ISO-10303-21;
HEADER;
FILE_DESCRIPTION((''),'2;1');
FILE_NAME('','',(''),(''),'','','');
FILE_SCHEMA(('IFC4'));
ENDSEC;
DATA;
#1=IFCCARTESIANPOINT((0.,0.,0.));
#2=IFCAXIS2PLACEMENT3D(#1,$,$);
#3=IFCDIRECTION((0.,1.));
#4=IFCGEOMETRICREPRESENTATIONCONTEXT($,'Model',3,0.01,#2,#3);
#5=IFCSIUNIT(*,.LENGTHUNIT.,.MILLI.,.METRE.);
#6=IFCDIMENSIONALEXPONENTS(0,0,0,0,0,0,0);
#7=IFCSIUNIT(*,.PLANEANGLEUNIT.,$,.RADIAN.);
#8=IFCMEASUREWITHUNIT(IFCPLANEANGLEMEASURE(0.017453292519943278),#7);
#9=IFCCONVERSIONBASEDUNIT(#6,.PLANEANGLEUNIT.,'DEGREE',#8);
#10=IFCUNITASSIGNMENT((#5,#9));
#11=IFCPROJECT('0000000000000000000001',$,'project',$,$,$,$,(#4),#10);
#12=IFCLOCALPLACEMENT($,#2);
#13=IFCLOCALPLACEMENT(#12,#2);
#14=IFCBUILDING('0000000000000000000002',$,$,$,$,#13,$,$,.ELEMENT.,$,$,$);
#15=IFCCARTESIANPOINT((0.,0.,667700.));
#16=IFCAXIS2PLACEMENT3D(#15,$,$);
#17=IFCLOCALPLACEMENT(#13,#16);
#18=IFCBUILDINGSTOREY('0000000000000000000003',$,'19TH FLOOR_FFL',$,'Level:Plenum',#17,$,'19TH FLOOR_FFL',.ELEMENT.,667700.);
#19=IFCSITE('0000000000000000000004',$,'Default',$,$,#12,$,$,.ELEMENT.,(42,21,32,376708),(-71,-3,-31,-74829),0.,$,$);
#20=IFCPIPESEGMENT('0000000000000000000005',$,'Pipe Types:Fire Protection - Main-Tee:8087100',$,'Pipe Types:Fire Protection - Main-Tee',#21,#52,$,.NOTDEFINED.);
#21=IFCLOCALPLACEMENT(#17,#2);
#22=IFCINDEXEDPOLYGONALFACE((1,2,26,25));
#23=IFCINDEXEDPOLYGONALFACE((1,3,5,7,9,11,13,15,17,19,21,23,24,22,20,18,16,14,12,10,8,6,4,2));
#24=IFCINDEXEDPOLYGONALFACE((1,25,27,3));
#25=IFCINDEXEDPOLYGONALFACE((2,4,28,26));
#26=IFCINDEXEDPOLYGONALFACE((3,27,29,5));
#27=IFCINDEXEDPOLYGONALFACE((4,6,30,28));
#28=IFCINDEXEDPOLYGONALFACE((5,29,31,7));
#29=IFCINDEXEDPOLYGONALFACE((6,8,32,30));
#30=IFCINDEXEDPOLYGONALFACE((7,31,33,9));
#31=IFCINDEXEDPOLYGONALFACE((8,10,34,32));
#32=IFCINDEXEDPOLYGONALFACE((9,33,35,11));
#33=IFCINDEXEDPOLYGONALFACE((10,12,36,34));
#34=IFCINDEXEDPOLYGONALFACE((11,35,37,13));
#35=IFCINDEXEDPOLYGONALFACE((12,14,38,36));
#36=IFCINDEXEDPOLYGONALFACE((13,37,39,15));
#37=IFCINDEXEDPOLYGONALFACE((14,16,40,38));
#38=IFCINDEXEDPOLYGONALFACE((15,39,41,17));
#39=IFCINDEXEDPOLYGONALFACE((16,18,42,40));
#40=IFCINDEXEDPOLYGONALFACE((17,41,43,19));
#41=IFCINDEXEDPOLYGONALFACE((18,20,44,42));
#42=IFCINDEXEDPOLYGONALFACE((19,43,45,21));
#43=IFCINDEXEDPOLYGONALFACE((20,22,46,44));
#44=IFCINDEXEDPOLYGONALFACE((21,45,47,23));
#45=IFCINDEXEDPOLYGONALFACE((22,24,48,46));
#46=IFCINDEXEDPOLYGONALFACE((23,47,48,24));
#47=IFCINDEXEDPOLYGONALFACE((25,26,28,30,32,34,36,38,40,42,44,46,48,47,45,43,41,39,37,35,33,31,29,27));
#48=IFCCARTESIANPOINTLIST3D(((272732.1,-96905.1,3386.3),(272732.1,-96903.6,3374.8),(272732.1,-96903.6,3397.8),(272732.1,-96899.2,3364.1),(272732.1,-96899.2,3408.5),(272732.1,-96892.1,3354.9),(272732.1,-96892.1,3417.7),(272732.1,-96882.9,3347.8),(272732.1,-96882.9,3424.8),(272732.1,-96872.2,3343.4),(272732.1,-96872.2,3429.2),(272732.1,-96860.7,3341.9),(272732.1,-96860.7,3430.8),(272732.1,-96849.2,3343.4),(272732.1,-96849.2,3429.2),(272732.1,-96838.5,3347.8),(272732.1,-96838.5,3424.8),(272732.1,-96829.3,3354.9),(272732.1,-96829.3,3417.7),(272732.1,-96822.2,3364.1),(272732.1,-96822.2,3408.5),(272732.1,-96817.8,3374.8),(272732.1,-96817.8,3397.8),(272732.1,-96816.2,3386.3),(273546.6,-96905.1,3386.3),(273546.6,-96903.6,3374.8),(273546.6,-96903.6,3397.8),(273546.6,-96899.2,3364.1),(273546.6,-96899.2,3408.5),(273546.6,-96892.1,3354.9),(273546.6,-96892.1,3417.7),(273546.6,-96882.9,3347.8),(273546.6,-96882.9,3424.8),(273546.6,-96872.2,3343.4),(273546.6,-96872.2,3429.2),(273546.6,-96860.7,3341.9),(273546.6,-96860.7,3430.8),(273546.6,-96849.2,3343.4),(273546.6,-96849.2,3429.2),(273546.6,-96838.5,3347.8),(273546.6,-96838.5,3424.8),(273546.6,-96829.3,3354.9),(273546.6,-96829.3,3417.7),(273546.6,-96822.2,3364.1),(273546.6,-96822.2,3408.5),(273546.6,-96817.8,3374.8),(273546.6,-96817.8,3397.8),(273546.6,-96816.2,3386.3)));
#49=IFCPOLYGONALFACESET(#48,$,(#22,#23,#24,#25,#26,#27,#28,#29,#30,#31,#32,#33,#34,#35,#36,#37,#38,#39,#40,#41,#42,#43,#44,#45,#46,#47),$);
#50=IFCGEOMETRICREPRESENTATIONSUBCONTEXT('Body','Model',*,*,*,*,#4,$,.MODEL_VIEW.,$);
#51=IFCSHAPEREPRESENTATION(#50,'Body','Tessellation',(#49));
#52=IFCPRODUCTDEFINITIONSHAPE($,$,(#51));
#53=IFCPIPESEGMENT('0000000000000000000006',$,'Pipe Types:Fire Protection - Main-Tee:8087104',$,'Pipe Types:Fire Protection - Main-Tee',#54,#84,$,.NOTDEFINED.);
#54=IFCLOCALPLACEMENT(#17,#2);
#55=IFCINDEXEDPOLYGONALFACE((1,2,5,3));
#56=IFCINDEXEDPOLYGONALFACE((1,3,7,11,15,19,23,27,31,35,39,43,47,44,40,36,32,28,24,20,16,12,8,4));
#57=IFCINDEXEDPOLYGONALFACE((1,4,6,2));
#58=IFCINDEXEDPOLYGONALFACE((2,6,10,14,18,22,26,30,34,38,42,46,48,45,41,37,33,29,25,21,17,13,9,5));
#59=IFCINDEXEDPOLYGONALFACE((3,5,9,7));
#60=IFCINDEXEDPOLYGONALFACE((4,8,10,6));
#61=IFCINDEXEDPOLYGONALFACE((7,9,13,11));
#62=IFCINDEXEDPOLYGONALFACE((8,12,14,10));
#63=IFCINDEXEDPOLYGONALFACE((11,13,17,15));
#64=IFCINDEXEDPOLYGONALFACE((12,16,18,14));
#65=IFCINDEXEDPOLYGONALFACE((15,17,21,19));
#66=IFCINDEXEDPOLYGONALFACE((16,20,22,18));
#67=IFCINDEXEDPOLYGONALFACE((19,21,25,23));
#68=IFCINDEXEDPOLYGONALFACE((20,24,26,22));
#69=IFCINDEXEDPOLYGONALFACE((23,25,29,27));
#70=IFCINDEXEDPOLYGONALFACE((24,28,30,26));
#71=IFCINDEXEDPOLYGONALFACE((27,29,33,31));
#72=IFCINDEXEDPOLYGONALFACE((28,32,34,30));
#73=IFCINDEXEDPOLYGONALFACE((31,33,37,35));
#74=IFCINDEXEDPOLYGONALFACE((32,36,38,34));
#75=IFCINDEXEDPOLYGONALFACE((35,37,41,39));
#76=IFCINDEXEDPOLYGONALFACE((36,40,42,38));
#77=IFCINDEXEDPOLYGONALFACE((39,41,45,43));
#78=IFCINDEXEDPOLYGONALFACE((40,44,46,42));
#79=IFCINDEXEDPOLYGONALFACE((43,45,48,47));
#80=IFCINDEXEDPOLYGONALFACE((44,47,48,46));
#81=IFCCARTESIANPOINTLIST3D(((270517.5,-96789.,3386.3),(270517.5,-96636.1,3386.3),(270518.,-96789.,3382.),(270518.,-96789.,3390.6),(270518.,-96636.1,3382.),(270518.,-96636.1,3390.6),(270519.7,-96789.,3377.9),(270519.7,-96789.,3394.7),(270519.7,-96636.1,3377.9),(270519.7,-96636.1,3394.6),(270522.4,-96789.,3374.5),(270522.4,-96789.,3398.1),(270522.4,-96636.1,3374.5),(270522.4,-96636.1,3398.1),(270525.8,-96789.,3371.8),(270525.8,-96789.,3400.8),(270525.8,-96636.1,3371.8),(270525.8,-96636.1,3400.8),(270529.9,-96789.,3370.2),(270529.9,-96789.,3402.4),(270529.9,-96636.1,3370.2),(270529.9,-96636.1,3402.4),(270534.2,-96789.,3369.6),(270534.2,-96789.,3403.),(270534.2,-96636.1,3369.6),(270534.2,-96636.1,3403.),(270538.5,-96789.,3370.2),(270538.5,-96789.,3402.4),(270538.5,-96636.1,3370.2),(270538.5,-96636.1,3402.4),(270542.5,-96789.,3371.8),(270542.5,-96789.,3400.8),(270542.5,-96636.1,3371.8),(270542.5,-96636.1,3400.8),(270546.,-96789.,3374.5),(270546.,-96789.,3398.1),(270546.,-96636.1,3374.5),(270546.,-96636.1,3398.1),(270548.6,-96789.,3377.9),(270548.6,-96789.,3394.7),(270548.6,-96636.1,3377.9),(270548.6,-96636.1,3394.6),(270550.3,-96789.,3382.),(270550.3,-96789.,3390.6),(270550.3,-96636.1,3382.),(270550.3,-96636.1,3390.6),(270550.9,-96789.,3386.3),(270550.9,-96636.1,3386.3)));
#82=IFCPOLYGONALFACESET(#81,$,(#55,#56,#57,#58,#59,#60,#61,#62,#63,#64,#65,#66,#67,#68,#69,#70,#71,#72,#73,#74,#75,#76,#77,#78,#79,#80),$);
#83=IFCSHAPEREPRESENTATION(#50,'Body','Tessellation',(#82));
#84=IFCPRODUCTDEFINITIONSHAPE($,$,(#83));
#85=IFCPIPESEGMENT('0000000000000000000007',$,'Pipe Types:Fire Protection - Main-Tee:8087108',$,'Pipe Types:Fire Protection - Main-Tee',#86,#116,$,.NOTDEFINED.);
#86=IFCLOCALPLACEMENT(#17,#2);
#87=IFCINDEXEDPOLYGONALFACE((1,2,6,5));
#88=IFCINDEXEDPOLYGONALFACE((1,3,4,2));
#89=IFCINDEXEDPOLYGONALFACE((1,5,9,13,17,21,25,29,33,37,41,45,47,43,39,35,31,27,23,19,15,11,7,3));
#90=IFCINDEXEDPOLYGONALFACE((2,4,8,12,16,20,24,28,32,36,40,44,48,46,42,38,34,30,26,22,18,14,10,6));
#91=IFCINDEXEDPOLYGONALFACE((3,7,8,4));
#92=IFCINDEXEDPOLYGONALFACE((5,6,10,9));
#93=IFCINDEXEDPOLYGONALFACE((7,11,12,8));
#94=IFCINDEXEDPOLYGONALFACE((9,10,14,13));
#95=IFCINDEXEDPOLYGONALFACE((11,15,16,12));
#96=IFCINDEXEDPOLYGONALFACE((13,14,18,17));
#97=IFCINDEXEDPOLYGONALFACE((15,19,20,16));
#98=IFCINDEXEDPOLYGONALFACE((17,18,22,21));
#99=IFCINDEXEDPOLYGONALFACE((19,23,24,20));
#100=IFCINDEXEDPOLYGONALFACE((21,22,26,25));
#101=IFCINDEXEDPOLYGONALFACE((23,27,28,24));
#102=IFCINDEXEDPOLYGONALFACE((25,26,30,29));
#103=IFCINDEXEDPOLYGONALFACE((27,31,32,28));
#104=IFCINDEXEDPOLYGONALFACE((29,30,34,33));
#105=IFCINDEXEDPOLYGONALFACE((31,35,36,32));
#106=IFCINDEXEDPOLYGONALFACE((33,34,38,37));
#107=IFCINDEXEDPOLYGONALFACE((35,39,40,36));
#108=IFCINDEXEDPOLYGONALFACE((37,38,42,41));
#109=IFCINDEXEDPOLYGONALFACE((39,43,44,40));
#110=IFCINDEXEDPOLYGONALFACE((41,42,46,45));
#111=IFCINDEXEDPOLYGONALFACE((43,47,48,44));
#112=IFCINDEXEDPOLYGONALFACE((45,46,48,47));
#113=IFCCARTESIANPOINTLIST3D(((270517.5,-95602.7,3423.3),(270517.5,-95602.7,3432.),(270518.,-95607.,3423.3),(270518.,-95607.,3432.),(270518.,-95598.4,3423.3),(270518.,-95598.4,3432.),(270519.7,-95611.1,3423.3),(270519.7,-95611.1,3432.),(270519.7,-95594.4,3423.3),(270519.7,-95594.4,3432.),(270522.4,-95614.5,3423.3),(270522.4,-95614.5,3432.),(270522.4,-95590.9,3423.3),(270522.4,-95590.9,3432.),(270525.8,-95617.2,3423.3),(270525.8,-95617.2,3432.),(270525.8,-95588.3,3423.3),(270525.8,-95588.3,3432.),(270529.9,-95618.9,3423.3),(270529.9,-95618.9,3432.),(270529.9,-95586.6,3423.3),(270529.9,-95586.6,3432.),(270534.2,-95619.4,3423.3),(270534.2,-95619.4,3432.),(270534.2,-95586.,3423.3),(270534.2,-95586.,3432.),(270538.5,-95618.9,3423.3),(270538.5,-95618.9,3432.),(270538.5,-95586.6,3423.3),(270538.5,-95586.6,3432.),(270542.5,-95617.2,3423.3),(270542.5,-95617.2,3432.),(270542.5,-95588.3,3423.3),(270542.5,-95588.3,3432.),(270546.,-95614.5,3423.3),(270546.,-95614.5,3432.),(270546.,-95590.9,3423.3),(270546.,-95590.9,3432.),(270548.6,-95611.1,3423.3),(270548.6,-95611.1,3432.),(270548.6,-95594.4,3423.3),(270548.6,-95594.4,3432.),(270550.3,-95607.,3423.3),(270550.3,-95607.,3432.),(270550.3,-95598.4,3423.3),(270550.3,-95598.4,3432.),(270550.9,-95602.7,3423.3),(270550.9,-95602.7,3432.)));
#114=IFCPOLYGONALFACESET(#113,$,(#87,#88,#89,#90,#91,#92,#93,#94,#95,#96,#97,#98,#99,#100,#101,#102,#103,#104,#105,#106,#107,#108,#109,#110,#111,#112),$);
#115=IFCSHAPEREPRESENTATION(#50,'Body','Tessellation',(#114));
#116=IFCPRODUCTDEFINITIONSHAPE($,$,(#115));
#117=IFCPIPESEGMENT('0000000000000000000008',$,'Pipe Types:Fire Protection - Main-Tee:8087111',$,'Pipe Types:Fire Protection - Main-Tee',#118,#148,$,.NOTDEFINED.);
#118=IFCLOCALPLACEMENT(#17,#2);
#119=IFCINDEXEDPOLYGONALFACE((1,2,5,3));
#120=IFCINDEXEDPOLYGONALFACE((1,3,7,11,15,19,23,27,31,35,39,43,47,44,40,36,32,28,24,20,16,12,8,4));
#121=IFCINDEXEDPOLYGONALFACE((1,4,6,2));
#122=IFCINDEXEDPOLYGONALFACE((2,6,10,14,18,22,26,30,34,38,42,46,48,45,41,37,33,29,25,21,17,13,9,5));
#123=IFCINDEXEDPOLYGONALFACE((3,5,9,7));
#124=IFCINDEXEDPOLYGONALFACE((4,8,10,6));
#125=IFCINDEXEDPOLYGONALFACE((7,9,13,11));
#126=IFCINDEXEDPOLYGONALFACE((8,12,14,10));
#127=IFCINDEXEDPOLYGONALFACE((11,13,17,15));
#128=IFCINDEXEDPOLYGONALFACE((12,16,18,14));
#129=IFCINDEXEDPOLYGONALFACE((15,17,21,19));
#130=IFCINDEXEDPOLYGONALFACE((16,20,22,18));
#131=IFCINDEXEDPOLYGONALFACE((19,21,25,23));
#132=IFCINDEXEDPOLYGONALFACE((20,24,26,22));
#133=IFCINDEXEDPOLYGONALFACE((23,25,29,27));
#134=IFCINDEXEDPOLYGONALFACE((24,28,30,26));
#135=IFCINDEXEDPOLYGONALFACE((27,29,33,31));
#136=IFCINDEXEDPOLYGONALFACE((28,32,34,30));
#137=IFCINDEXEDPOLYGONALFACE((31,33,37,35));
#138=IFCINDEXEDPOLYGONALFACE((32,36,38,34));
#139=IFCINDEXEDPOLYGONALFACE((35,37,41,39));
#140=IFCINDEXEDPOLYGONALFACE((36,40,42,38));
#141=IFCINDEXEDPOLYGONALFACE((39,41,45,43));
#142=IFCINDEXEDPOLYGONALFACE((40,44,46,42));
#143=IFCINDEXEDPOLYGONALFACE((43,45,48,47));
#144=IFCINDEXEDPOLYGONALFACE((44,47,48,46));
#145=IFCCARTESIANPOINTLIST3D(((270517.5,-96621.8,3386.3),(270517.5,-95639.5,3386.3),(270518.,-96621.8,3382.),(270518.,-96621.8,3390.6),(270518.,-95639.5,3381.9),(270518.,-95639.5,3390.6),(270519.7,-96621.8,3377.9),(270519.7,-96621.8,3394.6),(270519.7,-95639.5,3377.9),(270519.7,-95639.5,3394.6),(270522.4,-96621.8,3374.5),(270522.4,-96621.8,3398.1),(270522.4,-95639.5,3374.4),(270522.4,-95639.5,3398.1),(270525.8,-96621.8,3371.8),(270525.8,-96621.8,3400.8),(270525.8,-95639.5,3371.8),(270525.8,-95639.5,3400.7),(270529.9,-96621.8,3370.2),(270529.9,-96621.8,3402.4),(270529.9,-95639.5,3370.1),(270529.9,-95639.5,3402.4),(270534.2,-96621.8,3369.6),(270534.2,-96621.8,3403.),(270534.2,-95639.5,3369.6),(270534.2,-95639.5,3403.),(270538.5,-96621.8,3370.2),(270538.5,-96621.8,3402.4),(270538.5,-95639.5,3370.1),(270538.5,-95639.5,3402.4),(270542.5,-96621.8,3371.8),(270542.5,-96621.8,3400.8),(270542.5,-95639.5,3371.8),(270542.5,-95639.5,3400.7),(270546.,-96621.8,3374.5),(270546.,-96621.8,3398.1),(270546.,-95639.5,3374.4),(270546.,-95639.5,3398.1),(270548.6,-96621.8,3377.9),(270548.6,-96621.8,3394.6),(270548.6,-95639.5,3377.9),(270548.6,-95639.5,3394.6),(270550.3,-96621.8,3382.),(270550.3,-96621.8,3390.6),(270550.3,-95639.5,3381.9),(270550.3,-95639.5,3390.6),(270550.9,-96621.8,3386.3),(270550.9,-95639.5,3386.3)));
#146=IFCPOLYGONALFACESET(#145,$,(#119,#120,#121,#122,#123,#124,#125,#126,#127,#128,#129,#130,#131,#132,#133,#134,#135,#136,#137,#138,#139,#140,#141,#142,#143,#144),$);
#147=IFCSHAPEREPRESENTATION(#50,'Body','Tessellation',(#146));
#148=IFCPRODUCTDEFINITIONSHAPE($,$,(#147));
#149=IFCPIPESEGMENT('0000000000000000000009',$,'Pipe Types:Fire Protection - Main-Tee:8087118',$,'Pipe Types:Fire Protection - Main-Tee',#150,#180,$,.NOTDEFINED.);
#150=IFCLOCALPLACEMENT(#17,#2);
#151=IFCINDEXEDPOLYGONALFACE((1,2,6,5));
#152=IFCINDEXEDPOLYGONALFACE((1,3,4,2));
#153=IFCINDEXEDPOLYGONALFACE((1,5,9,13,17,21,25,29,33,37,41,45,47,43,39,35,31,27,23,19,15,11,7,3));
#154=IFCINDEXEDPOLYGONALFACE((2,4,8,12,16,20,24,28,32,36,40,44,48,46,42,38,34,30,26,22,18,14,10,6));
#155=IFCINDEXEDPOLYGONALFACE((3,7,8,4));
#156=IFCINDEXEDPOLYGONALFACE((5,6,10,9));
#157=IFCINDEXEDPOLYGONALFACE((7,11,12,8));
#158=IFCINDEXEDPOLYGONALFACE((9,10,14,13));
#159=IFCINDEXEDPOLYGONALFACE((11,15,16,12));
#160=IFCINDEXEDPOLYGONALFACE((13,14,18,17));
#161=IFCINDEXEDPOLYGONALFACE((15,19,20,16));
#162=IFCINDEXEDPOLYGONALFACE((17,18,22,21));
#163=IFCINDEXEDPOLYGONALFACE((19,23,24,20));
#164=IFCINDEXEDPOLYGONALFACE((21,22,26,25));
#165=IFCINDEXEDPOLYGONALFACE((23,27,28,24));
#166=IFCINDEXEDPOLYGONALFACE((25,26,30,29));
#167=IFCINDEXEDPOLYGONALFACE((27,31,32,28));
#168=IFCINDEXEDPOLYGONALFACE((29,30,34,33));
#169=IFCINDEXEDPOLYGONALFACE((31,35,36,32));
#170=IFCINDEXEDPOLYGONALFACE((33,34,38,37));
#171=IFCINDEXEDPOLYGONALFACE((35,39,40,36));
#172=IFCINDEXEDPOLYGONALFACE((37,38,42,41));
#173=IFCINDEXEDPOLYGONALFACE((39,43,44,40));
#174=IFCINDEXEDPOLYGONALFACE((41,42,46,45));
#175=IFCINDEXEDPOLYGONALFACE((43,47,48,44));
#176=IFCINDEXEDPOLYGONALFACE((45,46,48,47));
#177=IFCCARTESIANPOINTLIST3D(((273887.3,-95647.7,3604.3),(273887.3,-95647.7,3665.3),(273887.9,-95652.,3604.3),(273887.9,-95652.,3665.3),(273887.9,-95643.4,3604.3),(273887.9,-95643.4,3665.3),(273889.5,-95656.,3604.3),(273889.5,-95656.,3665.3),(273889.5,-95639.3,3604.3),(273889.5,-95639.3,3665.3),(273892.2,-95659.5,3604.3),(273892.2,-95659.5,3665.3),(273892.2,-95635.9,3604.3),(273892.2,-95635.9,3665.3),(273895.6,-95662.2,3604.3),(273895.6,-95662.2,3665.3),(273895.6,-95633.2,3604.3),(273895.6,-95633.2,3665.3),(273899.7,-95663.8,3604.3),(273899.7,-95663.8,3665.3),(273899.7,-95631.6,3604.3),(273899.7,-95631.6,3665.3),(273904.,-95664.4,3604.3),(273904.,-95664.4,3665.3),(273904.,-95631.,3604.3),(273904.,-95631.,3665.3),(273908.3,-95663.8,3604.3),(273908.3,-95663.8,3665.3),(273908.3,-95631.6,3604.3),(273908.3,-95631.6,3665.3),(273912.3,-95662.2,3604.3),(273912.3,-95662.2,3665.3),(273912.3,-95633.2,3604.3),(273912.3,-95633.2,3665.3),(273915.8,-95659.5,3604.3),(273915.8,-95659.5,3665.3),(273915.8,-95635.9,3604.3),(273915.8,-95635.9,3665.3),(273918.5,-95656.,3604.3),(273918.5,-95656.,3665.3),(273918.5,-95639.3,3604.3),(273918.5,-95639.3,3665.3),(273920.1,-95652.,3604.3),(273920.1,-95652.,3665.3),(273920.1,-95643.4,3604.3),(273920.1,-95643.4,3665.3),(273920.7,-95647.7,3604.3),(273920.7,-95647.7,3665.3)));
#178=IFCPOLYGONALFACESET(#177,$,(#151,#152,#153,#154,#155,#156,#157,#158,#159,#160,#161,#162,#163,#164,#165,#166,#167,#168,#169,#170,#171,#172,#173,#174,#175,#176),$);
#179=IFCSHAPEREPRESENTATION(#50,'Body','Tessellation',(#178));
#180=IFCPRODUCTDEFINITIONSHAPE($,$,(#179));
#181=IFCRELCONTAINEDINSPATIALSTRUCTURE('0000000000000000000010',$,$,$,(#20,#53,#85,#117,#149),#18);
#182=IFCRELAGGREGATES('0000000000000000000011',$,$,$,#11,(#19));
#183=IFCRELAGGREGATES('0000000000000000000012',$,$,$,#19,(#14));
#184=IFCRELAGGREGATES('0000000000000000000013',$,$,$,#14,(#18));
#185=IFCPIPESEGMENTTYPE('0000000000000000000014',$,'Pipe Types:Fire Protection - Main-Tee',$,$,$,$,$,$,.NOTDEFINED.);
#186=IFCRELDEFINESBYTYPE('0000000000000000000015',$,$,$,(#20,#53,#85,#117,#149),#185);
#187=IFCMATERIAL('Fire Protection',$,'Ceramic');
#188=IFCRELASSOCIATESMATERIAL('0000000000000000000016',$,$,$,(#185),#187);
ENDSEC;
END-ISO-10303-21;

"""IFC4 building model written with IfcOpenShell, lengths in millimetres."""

from ifc_helpers import new_model, entity, si_unit, converted_unit, direction, frame, origin, place, context, subcontext, project, spatial, arc, indexed_curve, outline, extrude, material, type_object, element, save


model = new_model("IFC4")

# Units and contexts
model_context = context("Model", 3, precision=0.01, world=origin(), true_north=direction((0.0, 1.0)))
body_context = subcontext(model_context, "Body", "Model", "MODEL_VIEW")
ifc_project = project(units=[si_unit("LENGTHUNIT", "METRE", prefix="MILLI"), converted_unit("PLANEANGLEUNIT", "DEGREE", entity("IfcPlaneAngleMeasure", 0.017453292519943278), si_unit("PLANEANGLEUNIT", "RADIAN"), dimensions=[0, 0, 0, 0, 0, 0, 0])], contexts=[model_context])

# Site, building, storey
site_placement = place(None, origin())
site = spatial("IfcSite", under=ifc_project, at=site_placement, Name="Default", CompositionType="ELEMENT", RefLatitude=(42, 21, 32, 376708), RefLongitude=(-71, -3, -31, -74829), RefElevation=0.0)
building_placement = place(site_placement, origin())
building = spatial("IfcBuilding", under=site, at=building_placement, CompositionType="ELEMENT")
storey_placement = place(building_placement, frame((0.0, 0.0, 667700.0)))
storey = spatial("IfcBuildingStorey", under=building, at=storey_placement, Name="19TH FLOOR_FFL", ObjectType="Level:Plenum", LongName="19TH FLOOR_FFL", CompositionType="ELEMENT", Elevation=667700.0)

# Pipe segments
ifc_material = material(Name="Fire Protection", Category="Ceramic")
pipe_segment_type = type_object("IfcPipeSegmentType", Name="Pipe Types:Fire Protection - Main-Tee", PredefinedType="NOTDEFINED", material=ifc_material)
pipe_segment_1_placement = place(storey_placement, origin())
element("IfcPipeSegment", 1, at=pipe_segment_1_placement, inside=storey, type_object=pipe_segment_type, Name="Pipe Types:Fire Protection - Main-Tee:8087100", ObjectType="Pipe Types:Fire Protection - Main-Tee", PredefinedType="NOTDEFINED", context=body_context, shape_type="SweptSolid", body=[
    extrude(outline(indexed_curve([(44.4, 0.0), (31.4, 31.4), (0.0, 44.5), (-31.4, 31.4), (-44.4, 0.0), (-31.4, -31.4), (0.0, -44.5), (31.4, -31.4)], segments=[arc(1, 2, 3), arc(3, 4, 5), arc(5, 6, 7), arc(7, 8, 1)], self_intersect=False)), frame((272732.1, -96860.7, 3386.3), z_axis=(1.0, 0.0, 0.0), x_axis=(0.0, 1.0, 0.0)), (0.0, 0.0, 1.0), 814.5),
])
pipe_segment_2_placement = place(storey_placement, origin())
element("IfcPipeSegment", 2, at=pipe_segment_2_placement, inside=storey, type_object=pipe_segment_type, Name="Pipe Types:Fire Protection - Main-Tee:8087104", ObjectType="Pipe Types:Fire Protection - Main-Tee", PredefinedType="NOTDEFINED", context=body_context, shape_type="SweptSolid", body=[
    extrude(outline(indexed_curve([(16.7, 0.0), (11.8, 11.8), (0.0, 16.7), (-11.8, 11.8), (-16.7, 0.0), (-11.8, -11.8), (0.0, -16.7), (11.8, -11.8)], segments=[arc(1, 2, 3), arc(3, 4, 5), arc(5, 6, 7), arc(7, 8, 1)], self_intersect=False)), frame((270534.2, -96789.0, 3386.3), z_axis=(0.0, 1.0, -0.000036), x_axis=(1.0, 0.0, 0.0)), (0.0, 0.0, 1.0), 152.9),
])
pipe_segment_3_placement = place(storey_placement, origin())
element("IfcPipeSegment", 3, at=pipe_segment_3_placement, inside=storey, type_object=pipe_segment_type, Name="Pipe Types:Fire Protection - Main-Tee:8087108", ObjectType="Pipe Types:Fire Protection - Main-Tee", PredefinedType="NOTDEFINED", context=body_context, shape_type="SweptSolid", body=[
    extrude(outline(indexed_curve([(16.7, 0.0), (11.8, 11.8), (0.0, 16.7), (-11.8, 11.8), (-16.7, 0.0), (-11.8, -11.8), (0.0, -16.7), (11.8, -11.8)], segments=[arc(1, 2, 3), arc(3, 4, 5), arc(5, 6, 7), arc(7, 8, 1)], self_intersect=False)), frame((270534.2, -95602.7, 3423.3)), (0.0, 0.0, 1.0), 8.7),
])
pipe_segment_4_placement = place(storey_placement, origin())
element("IfcPipeSegment", 4, at=pipe_segment_4_placement, inside=storey, type_object=pipe_segment_type, Name="Pipe Types:Fire Protection - Main-Tee:8087111", ObjectType="Pipe Types:Fire Protection - Main-Tee", PredefinedType="NOTDEFINED", context=body_context, shape_type="SweptSolid", body=[
    extrude(outline(indexed_curve([(16.7, 0.0), (11.8, 11.8), (0.0, 16.7), (-11.8, 11.8), (-16.7, 0.0), (-11.8, -11.8), (0.0, -16.7), (11.8, -11.8)], segments=[arc(1, 2, 3), arc(3, 4, 5), arc(5, 6, 7), arc(7, 8, 1)], self_intersect=False)), frame((270534.2, -96621.8, 3386.3), z_axis=(0.0, 1.0, -0.000036), x_axis=(1.0, 0.0, 0.0)), (0.0, 0.0, 1.0), 982.4),
])
pipe_segment_5_placement = place(storey_placement, origin())
element("IfcPipeSegment", 5, at=pipe_segment_5_placement, inside=storey, type_object=pipe_segment_type, Name="Pipe Types:Fire Protection - Main-Tee:8087118", ObjectType="Pipe Types:Fire Protection - Main-Tee", PredefinedType="NOTDEFINED", context=body_context, shape_type="SweptSolid", body=[
    extrude(outline(indexed_curve([(16.7, 0.0), (11.8, 11.8), (0.0, 16.7), (-11.8, 11.8), (-16.7, 0.0), (-11.8, -11.8), (0.0, -16.7), (11.8, -11.8)], segments=[arc(1, 2, 3), arc(3, 4, 5), arc(5, 6, 7), arc(7, 8, 1)], self_intersect=False)), frame((273904.0, -95647.7, 3604.3)), (0.0, 0.0, 1.0), 61.0),
])

save(model, "model.ifc")
